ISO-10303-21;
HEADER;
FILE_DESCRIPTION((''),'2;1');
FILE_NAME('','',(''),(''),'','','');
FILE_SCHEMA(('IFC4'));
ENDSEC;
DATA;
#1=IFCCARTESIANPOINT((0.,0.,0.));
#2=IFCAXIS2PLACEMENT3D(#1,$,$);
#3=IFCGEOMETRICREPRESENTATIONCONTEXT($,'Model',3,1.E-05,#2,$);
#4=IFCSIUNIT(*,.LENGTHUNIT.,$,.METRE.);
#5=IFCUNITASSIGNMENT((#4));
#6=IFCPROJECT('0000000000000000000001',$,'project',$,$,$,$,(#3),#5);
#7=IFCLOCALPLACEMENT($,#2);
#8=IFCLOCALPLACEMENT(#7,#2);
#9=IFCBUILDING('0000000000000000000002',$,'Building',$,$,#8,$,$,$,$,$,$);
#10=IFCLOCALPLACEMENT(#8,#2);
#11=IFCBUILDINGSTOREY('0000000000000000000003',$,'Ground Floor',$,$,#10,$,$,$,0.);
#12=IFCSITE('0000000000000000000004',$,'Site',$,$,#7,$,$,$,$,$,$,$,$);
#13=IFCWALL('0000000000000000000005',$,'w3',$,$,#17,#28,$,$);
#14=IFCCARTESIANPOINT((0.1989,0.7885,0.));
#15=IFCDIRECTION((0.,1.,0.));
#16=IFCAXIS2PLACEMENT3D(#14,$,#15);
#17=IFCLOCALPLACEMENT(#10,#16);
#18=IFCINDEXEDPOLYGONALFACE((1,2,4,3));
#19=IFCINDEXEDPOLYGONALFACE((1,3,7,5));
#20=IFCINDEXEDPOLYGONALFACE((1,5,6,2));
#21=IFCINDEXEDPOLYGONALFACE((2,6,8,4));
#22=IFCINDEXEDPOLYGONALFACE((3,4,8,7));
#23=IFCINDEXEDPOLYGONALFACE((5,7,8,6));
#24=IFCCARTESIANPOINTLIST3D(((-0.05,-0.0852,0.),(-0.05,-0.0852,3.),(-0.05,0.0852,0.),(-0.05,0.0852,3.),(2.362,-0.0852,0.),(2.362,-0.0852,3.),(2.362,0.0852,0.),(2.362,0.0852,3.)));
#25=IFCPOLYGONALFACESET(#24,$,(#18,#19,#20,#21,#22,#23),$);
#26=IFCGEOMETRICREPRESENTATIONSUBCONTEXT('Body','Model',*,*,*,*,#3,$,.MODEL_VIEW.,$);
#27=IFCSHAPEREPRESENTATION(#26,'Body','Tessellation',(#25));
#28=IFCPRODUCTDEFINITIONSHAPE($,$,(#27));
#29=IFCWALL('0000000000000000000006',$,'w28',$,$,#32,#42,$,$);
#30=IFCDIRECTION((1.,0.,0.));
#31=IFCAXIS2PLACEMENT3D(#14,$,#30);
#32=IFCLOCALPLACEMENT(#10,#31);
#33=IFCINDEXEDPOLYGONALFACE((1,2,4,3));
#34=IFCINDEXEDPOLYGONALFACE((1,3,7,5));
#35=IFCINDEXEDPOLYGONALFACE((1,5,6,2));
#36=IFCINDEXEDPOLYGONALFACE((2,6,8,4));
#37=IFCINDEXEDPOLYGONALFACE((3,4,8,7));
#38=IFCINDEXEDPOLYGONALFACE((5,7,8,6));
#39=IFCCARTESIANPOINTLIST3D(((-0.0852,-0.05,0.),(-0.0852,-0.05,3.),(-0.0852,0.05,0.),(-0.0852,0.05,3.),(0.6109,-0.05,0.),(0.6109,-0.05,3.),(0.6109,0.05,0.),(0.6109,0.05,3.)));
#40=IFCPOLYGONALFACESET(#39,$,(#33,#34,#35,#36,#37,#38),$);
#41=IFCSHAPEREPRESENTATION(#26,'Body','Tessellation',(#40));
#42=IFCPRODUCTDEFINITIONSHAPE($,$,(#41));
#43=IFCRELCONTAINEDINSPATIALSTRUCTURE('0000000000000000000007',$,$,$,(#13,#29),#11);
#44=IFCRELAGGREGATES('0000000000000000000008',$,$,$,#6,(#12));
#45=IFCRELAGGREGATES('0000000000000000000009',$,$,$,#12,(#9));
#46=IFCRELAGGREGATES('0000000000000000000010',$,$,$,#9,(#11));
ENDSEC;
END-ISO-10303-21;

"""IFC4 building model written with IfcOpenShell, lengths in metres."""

from ifc_helpers import new_model, si_unit, frame, origin, place, context, subcontext, project, spatial, polyline, outline, extrude, element, save


model = new_model("IFC4")

# Units and contexts
model_context = context("Model", 3, precision=1e-05, world=origin())
body_context = subcontext(model_context, "Body", "Model", "MODEL_VIEW")
ifc_project = project(units=[si_unit("LENGTHUNIT", "METRE")], contexts=[model_context])

# Site, building, storey
site_placement = place(None, origin())
site = spatial("IfcSite", under=ifc_project, at=site_placement, Name="Site")
building_placement = place(site_placement, origin())
building = spatial("IfcBuilding", under=site, at=building_placement, Name="Building")
storey_placement = place(building_placement, origin())
storey = spatial("IfcBuildingStorey", under=building, at=storey_placement, Name="Ground Floor", Elevation=0.0)

# Wall
wall_1_placement = place(storey_placement, frame((0.1989, 0.7885, 0.0), x_axis=(0.0, 1.0, 0.0)))
element("IfcWall", 1, at=wall_1_placement, inside=storey, Name="w3", context=body_context, shape_type="SweptSolid", body=[
    extrude(outline(polyline([(-0.05, -0.0852), (2.362, -0.0852), (2.362, 0.0852), (-0.05, 0.0852), (-0.05, -0.0852)])), origin(), (0.0, 0.0, 1.0), 3.0),
])

# Wall
wall_2_placement = place(storey_placement, frame((0.1989, 0.7885, 0.0), x_axis=(1.0, 0.0, 0.0)))
element("IfcWall", 2, at=wall_2_placement, inside=storey, Name="w28", context=body_context, shape_type="SweptSolid", body=[
    extrude(outline(polyline([(-0.0852, -0.05), (0.6109, -0.05), (0.6109, 0.05), (-0.0852, 0.05), (-0.0852, -0.05)])), origin(), (0.0, 0.0, 1.0), 3.0),
])

save(model, "model.ifc")
